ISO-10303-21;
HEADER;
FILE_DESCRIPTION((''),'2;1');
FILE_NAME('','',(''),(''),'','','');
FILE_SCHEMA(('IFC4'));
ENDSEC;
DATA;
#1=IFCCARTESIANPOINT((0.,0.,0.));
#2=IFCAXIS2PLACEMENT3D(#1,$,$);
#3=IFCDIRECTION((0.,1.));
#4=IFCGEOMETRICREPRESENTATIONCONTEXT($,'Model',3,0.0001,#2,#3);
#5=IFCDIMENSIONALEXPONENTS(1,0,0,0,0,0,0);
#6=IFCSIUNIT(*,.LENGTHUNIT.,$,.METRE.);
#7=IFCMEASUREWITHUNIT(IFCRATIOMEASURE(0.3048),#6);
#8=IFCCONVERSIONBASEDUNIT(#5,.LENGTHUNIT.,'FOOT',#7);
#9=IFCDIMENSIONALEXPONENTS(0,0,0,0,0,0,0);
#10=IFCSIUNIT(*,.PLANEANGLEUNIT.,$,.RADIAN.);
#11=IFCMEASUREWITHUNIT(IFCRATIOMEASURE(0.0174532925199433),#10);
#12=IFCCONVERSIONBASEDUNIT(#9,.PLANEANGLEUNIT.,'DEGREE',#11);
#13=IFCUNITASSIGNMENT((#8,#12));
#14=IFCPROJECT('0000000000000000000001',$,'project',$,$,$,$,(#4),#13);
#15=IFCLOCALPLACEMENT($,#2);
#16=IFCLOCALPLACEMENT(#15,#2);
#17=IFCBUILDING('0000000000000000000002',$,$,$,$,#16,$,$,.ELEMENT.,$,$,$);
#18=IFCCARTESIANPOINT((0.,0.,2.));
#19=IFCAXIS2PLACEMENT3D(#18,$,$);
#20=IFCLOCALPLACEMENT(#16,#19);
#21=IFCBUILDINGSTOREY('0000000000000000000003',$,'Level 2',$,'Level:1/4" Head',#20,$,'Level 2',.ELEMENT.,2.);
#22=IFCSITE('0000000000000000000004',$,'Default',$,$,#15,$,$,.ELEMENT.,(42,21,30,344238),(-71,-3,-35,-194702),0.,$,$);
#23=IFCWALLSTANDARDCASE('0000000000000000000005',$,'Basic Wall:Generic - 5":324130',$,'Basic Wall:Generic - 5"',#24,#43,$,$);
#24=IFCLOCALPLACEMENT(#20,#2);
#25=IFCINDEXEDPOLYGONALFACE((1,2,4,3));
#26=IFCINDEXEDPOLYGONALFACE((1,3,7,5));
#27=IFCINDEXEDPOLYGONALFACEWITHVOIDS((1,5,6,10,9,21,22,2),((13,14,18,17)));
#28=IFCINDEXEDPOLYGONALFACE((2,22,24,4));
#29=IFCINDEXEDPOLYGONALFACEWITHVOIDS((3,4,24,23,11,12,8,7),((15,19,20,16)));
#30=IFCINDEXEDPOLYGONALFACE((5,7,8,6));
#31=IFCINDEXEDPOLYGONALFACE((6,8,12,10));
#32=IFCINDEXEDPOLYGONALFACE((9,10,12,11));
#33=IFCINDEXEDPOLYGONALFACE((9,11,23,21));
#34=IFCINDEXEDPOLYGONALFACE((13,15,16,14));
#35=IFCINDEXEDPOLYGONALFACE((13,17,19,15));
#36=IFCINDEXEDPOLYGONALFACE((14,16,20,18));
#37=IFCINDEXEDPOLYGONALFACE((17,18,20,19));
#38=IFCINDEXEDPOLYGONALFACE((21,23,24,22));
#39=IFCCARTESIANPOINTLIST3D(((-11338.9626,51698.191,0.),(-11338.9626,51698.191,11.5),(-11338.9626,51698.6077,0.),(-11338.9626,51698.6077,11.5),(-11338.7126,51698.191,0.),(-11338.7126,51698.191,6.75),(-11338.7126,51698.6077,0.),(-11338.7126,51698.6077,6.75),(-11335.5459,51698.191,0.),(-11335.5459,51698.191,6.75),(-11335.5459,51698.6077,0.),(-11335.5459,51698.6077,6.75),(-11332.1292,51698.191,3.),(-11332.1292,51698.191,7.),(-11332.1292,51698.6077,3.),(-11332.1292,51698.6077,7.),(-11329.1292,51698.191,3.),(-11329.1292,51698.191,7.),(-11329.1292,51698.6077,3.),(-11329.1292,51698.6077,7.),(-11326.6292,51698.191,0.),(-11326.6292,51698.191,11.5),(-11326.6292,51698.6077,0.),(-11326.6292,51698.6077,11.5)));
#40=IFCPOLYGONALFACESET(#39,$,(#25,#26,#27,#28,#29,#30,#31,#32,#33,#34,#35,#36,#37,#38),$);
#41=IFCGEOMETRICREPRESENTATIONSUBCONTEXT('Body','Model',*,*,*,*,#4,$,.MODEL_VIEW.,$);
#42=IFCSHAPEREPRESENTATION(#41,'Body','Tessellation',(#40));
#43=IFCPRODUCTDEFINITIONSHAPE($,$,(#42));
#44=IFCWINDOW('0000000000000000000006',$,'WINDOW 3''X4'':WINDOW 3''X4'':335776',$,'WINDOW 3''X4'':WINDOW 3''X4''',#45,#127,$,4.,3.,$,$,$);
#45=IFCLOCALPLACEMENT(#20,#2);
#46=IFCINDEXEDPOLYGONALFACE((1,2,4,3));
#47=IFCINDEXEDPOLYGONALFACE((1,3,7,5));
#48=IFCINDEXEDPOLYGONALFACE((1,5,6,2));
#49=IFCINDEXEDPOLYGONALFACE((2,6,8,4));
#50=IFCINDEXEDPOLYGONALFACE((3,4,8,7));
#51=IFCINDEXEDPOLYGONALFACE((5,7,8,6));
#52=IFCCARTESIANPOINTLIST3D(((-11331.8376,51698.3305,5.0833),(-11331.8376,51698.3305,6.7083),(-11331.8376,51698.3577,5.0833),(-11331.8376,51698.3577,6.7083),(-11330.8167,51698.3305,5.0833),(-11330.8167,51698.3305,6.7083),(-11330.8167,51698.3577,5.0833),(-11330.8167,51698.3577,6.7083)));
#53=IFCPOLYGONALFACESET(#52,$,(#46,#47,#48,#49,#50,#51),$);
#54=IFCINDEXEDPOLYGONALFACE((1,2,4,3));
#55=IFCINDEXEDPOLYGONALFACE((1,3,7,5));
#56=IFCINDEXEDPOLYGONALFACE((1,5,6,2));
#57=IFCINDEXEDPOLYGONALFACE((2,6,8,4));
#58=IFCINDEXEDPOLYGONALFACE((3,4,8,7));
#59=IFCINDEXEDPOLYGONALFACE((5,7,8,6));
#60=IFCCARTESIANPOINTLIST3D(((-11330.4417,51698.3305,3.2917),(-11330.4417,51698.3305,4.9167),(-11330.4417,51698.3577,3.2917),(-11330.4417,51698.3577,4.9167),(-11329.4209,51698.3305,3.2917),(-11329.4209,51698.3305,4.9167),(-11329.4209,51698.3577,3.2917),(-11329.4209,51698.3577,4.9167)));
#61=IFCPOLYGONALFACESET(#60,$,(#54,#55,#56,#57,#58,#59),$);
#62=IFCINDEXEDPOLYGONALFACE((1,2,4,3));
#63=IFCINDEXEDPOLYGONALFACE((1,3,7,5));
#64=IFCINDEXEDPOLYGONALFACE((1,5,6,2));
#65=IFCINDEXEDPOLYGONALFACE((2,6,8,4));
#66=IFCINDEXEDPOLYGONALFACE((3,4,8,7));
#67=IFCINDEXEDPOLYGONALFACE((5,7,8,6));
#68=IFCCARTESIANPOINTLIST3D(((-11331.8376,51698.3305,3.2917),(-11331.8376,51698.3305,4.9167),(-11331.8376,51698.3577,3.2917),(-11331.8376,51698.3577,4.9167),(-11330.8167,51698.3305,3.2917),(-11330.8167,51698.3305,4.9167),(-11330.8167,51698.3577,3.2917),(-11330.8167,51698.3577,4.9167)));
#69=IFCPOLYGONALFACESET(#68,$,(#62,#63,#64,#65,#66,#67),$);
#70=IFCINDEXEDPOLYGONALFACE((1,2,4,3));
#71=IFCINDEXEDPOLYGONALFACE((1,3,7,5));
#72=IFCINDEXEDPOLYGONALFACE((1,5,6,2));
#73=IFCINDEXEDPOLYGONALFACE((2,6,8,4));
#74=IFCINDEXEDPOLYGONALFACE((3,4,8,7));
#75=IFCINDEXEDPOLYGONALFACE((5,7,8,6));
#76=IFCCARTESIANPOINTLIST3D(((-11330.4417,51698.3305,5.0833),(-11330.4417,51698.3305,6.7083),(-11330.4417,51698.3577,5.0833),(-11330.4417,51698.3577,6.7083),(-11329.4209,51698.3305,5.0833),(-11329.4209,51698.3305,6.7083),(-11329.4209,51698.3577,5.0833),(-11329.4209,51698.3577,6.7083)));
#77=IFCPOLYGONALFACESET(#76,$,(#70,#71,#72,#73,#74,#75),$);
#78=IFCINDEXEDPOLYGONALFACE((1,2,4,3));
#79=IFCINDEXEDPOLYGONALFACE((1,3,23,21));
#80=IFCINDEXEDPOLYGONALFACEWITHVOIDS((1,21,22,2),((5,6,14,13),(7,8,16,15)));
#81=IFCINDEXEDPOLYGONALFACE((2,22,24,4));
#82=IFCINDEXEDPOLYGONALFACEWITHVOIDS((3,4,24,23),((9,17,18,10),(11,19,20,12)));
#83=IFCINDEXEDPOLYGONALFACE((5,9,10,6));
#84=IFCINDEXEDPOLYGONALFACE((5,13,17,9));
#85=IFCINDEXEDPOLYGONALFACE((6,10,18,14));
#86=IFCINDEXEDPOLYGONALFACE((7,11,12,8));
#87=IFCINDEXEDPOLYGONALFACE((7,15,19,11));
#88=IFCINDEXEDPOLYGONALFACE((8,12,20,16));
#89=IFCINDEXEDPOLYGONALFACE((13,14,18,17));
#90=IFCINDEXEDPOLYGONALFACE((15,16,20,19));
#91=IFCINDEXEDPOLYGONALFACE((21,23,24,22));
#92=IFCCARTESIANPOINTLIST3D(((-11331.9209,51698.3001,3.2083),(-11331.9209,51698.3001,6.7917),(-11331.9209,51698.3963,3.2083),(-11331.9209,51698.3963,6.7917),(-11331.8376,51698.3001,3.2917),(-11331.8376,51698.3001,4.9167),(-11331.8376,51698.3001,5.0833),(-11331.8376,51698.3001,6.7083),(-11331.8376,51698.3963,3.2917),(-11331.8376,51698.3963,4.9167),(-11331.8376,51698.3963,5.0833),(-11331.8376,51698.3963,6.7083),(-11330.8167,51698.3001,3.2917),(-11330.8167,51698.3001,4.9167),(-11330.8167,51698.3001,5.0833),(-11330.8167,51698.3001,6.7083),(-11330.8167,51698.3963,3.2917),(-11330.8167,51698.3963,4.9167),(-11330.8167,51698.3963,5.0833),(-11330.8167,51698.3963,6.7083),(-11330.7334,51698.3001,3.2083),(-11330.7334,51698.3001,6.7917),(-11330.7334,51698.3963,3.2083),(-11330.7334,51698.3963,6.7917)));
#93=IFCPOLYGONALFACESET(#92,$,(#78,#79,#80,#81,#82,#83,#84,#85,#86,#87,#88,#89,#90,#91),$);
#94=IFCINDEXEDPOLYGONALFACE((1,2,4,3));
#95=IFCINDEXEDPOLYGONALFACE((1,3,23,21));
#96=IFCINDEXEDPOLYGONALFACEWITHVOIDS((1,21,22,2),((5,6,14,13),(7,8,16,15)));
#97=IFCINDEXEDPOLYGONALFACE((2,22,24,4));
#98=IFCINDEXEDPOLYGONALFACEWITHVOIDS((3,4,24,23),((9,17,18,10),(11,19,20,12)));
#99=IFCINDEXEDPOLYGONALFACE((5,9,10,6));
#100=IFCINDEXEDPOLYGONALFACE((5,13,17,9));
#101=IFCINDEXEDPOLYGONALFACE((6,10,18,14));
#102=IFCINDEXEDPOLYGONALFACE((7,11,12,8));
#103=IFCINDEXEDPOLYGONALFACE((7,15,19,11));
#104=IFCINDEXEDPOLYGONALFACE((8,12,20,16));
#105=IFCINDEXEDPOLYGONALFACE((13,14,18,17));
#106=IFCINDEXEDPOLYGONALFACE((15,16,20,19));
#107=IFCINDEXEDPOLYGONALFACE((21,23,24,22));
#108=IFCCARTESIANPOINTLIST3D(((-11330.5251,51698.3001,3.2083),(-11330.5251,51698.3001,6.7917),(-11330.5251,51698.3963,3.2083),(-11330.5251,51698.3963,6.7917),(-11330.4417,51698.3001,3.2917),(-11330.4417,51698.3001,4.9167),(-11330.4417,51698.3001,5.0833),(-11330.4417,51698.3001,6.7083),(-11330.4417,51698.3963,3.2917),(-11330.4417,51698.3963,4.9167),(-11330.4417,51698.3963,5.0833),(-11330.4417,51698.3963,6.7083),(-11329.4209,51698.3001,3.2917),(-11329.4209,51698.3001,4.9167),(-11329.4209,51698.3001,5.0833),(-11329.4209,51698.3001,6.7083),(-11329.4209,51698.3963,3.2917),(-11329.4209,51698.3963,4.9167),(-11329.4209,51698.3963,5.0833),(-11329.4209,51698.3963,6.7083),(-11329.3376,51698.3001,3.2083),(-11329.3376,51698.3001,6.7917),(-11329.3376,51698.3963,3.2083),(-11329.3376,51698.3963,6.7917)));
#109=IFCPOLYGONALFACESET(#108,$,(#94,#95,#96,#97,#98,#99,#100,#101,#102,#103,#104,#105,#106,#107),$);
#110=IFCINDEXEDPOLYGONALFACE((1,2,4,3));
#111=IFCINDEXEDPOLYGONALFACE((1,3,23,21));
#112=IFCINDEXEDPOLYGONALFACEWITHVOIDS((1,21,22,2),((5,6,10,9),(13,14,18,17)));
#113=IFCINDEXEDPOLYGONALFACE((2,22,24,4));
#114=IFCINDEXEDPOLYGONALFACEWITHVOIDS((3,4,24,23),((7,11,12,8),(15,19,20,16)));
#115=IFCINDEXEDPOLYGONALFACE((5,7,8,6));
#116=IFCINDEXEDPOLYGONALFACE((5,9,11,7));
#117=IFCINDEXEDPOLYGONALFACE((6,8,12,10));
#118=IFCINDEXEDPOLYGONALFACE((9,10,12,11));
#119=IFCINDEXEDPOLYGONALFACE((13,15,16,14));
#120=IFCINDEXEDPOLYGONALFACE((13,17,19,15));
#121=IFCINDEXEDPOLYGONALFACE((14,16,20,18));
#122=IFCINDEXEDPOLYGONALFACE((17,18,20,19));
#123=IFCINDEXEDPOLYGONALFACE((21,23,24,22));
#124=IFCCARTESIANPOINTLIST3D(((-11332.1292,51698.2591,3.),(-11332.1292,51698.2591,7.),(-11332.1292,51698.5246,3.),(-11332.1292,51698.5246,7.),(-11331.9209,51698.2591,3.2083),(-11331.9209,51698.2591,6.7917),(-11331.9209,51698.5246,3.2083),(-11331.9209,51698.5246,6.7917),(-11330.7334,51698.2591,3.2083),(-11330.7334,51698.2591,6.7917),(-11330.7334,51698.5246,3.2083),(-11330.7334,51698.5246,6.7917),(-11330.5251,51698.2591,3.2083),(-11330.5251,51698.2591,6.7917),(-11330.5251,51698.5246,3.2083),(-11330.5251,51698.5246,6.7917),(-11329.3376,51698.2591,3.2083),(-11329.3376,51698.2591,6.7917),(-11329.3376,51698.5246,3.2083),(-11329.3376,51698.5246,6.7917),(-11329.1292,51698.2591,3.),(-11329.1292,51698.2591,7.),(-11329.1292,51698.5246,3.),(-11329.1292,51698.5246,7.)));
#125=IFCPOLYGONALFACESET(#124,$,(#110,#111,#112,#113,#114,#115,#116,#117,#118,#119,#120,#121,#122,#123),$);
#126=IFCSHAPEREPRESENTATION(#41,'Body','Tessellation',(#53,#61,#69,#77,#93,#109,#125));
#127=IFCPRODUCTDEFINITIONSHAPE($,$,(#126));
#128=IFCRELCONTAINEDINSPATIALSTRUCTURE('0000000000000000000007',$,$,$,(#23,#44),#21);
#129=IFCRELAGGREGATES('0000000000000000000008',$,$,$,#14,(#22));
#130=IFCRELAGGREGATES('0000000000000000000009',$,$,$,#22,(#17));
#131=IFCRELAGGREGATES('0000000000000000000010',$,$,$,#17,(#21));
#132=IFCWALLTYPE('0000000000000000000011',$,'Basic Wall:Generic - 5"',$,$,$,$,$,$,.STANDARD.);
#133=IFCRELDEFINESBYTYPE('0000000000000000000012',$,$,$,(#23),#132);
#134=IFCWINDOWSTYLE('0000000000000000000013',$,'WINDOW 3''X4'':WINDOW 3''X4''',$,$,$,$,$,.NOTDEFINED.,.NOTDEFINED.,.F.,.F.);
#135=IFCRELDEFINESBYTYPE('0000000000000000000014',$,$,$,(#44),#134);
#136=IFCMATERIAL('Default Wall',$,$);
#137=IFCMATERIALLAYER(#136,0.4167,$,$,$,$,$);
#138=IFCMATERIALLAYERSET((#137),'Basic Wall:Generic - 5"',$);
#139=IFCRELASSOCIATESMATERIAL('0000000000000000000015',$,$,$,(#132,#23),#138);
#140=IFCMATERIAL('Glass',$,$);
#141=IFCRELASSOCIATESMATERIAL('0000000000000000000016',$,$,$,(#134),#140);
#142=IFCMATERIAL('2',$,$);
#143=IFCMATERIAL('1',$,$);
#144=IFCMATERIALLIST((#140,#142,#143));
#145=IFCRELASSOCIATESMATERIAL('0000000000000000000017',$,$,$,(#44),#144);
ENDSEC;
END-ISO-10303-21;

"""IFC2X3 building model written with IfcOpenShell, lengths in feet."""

from ifc_helpers import new_model, entity, si_unit, converted_unit, direction, frame, frame_2d, origin, origin_2d_with_axis, place, context, subcontext, project, spatial, polyline, rectangle, outline, extrude, source, transform, mapped, material, material_list, layer, layer_set, layer_usage, type_object, type_shapes, element, fill, save


model = new_model("IFC2X3")

# Units and contexts
model_context = context("Model", 3, precision=0.0001, world=origin(), true_north=direction((0.0, 1.0)))
body_context = subcontext(model_context, "Body", "Model", "MODEL_VIEW")
ifc_project = project(units=[converted_unit("LENGTHUNIT", "FOOT", entity("IfcRatioMeasure", 0.3048), si_unit("LENGTHUNIT", "METRE"), dimensions=[1, 0, 0, 0, 0, 0, 0]), converted_unit("PLANEANGLEUNIT", "DEGREE", entity("IfcRatioMeasure", 0.0174532925199433), si_unit("PLANEANGLEUNIT", "RADIAN"), dimensions=[0, 0, 0, 0, 0, 0, 0])], contexts=[model_context])

# Site, building, storey
site_placement = place(None, origin())
site = spatial("IfcSite", under=ifc_project, at=site_placement, Name="Default", CompositionType="ELEMENT", RefLatitude=(42, 21, 30, 344238), RefLongitude=(-71, -3, -35, -194702), RefElevation=0.0)
building_placement = place(site_placement, origin())
building = spatial("IfcBuilding", under=site, at=building_placement, CompositionType="ELEMENT")
storey_placement = place(building_placement, frame((0.0, 0.0, 2.0)))
storey = spatial("IfcBuildingStorey", under=building, at=storey_placement, Name="Level 2", ObjectType="Level:1/4\" Head", LongName="Level 2", CompositionType="ELEMENT", Elevation=2.0)

# Wall, openings, window
ifc_material_1 = material(Name="Default Wall")
ifc_layer_1 = layer(ifc_material_1, 0.4167)
ifc_layer_set_1 = layer_set([ifc_layer_1], Name="Basic Wall:Generic - 5\"")
wall_type = type_object("IfcWallType", Name="Basic Wall:Generic - 5\"", PredefinedType="STANDARD", material=ifc_layer_set_1)
ifc_material_2 = material(Name="Glass")
ifc_material_3 = material(Name="2")
ifc_material_4 = material(Name="1")
window_style = type_object("IfcWindowStyle", Name="WINDOW 3'X4':WINDOW 3'X4'", ConstructionType="NOTDEFINED", OperationType="NOTDEFINED", ParameterTakesPrecedence=False, Sizeable=False, material=ifc_material_2)
shared_shape = source(origin(), body_context, "Body", "SweptSolid", [
    extrude(rectangle(XDim=0.0272, YDim=1.0208, at=origin_2d_with_axis()), frame((2.1979, 0.2636, 2.0833), z_axis=(0.0, 0.0, 1.0), x_axis=(0.0, 1.0, 0.0)), (0.0, 0.0, 1.0), 1.625),
    extrude(rectangle(XDim=0.0272, YDim=1.0208, at=origin_2d_with_axis()), frame((0.8021, 0.2636, 0.2917), z_axis=(0.0, 0.0, 1.0), x_axis=(0.0, 1.0, 0.0)), (0.0, 0.0, 1.0), 1.625),
    extrude(rectangle(XDim=0.0272, YDim=1.0208, at=origin_2d_with_axis()), frame((2.1979, 0.2636, 0.2917), z_axis=(0.0, 0.0, 1.0), x_axis=(0.0, 1.0, 0.0)), (0.0, 0.0, 1.0), 1.625),
    extrude(rectangle(XDim=0.0272, YDim=1.0208, at=origin_2d_with_axis()), frame((0.8021, 0.2636, 2.0833), z_axis=(0.0, 0.0, 1.0), x_axis=(0.0, 1.0, 0.0)), (0.0, 0.0, 1.0), 1.625),
    extrude(outline(polyline([(-0.5938, -1.7917), (0.5938, -1.7917), (0.5938, 1.7917), (-0.5938, 1.7917), (-0.5938, -1.7917)]), holes=[polyline([(-0.5104, -0.0833), (0.5104, -0.0833), (0.5104, -1.7083), (-0.5104, -1.7083), (-0.5104, -0.0833)]), polyline([(-0.5104, 1.7083), (0.5104, 1.7083), (0.5104, 0.0833), (-0.5104, 0.0833), (-0.5104, 1.7083)])]), frame((2.1979, 0.2114, 2.0), z_axis=(0.0, 1.0, 0.0), x_axis=(-1.0, 0.0, 0.0)), (0.0, 0.0, 1.0), 0.0962),
    extrude(outline(polyline([(-1.7917, -0.5937), (1.7917, -0.5937), (1.7917, 0.5937), (-1.7917, 0.5937), (-1.7917, -0.5937)]), holes=[polyline([(0.0833, -0.5104), (0.0833, 0.5104), (1.7083, 0.5104), (1.7083, -0.5104), (0.0833, -0.5104)]), polyline([(-1.7083, -0.5104), (-1.7083, 0.5104), (-0.0833, 0.5104), (-0.0833, -0.5104), (-1.7083, -0.5104)])]), frame((0.8021, 0.2114, 2.0), z_axis=(0.0, 1.0, 0.0), x_axis=(0.0, 0.0, -1.0)), (0.0, 0.0, 1.0), 0.0962),
    extrude(outline(polyline([(-1.5, -2.0), (1.5, -2.0), (1.5, 2.0), (-1.5, 2.0), (-1.5, -2.0)]), holes=[polyline([(-0.1042, 1.7917), (-0.1042, -1.7917), (-1.2917, -1.7917), (-1.2917, 1.7917), (-0.1042, 1.7917)]), polyline([(0.1042, -1.7917), (0.1042, 1.7917), (1.2917, 1.7917), (1.2917, -1.7917), (0.1042, -1.7917)])]), frame((1.5, 0.0831, 2.0), z_axis=(0.0, 1.0, 0.0), x_axis=(1.0, 0.0, 0.0)), (0.0, 0.0, 1.0), 0.2655),
])
type_shapes(window_style, [shared_shape])
ifc_layer_usage_1 = layer_usage(ifc_layer_set_1, "AXIS2", "NEGATIVE", 0.2083)
wall_1_placement = place(storey_placement, frame((-11338.9626, 51698.3993, 0.0)))
wall_1 = element("IfcWallStandardCase", 1, at=wall_1_placement, inside=storey, type_object=wall_type, material=ifc_layer_usage_1, Name="Basic Wall:Generic - 5\":324130", ObjectType="Basic Wall:Generic - 5\"", context=body_context, shape_type="SweptSolid", body=[
    extrude(rectangle(XDim=12.3333, YDim=0.4167, at=frame_2d((6.1667, 0.0), x_axis=(-1.0, 0.0))), origin(), (0.0, 0.0, 1.0), 11.5),
])
opening_1_placement = place(wall_1_placement, frame((0.25, -0.2083, 0.0)))
element("IfcOpeningElement", 2, at=opening_1_placement, cuts=wall_1, ObjectType="Opening", context=body_context, shape_type="SweptSolid", body=[
    extrude(rectangle(XDim=6.75, YDim=3.1667, at=frame_2d((3.375, 1.5833), x_axis=(1.0, 0.0))), frame((0.0, 0.0, 0.0), z_axis=(0.0, 1.0, 0.0), x_axis=(0.0, 0.0, 1.0)), (0.0, 0.0, 1.0), 0.4167),
])
opening_2_placement = place(wall_1_placement, frame((9.8333, 0.2083, 3.0)))
opening_2 = element("IfcOpeningElement", 3, at=opening_2_placement, cuts=wall_1, ObjectType="Opening", context=body_context, shape_type="SweptSolid", body=[
    extrude(rectangle(XDim=4.0, YDim=3.0, at=frame_2d((2.0, 1.5), x_axis=(-1.0, 0.0))), frame((0.0, 0.0, 0.0), z_axis=(0.0, -1.0, 0.0), x_axis=(0.0, 0.0, 1.0)), (0.0, 0.0, 1.0), 0.4167),
])
ifc_material_list_1 = material_list([ifc_material_2, ifc_material_3, ifc_material_4])
window_1_placement = place(opening_2_placement, frame((0.0, 0.0, 0.0), z_axis=(0.0, 0.0, 1.0), x_axis=(-1.0, 0.0, 0.0)))
window_1 = element("IfcWindow", 4, at=window_1_placement, inside=storey, type_object=window_style, material=ifc_material_list_1, Name="WINDOW 3'X4':WINDOW 3'X4':335776", ObjectType="WINDOW 3'X4':WINDOW 3'X4'", OverallHeight=4.0, OverallWidth=3.0, context=body_context, shape_type="MappedRepresentation", body=[
    mapped(shared_shape, transform((0.0, 0.0, 0.0), scale=1.0)),
])
fill(opening_2, window_1)

save(model, "model.ifc")
